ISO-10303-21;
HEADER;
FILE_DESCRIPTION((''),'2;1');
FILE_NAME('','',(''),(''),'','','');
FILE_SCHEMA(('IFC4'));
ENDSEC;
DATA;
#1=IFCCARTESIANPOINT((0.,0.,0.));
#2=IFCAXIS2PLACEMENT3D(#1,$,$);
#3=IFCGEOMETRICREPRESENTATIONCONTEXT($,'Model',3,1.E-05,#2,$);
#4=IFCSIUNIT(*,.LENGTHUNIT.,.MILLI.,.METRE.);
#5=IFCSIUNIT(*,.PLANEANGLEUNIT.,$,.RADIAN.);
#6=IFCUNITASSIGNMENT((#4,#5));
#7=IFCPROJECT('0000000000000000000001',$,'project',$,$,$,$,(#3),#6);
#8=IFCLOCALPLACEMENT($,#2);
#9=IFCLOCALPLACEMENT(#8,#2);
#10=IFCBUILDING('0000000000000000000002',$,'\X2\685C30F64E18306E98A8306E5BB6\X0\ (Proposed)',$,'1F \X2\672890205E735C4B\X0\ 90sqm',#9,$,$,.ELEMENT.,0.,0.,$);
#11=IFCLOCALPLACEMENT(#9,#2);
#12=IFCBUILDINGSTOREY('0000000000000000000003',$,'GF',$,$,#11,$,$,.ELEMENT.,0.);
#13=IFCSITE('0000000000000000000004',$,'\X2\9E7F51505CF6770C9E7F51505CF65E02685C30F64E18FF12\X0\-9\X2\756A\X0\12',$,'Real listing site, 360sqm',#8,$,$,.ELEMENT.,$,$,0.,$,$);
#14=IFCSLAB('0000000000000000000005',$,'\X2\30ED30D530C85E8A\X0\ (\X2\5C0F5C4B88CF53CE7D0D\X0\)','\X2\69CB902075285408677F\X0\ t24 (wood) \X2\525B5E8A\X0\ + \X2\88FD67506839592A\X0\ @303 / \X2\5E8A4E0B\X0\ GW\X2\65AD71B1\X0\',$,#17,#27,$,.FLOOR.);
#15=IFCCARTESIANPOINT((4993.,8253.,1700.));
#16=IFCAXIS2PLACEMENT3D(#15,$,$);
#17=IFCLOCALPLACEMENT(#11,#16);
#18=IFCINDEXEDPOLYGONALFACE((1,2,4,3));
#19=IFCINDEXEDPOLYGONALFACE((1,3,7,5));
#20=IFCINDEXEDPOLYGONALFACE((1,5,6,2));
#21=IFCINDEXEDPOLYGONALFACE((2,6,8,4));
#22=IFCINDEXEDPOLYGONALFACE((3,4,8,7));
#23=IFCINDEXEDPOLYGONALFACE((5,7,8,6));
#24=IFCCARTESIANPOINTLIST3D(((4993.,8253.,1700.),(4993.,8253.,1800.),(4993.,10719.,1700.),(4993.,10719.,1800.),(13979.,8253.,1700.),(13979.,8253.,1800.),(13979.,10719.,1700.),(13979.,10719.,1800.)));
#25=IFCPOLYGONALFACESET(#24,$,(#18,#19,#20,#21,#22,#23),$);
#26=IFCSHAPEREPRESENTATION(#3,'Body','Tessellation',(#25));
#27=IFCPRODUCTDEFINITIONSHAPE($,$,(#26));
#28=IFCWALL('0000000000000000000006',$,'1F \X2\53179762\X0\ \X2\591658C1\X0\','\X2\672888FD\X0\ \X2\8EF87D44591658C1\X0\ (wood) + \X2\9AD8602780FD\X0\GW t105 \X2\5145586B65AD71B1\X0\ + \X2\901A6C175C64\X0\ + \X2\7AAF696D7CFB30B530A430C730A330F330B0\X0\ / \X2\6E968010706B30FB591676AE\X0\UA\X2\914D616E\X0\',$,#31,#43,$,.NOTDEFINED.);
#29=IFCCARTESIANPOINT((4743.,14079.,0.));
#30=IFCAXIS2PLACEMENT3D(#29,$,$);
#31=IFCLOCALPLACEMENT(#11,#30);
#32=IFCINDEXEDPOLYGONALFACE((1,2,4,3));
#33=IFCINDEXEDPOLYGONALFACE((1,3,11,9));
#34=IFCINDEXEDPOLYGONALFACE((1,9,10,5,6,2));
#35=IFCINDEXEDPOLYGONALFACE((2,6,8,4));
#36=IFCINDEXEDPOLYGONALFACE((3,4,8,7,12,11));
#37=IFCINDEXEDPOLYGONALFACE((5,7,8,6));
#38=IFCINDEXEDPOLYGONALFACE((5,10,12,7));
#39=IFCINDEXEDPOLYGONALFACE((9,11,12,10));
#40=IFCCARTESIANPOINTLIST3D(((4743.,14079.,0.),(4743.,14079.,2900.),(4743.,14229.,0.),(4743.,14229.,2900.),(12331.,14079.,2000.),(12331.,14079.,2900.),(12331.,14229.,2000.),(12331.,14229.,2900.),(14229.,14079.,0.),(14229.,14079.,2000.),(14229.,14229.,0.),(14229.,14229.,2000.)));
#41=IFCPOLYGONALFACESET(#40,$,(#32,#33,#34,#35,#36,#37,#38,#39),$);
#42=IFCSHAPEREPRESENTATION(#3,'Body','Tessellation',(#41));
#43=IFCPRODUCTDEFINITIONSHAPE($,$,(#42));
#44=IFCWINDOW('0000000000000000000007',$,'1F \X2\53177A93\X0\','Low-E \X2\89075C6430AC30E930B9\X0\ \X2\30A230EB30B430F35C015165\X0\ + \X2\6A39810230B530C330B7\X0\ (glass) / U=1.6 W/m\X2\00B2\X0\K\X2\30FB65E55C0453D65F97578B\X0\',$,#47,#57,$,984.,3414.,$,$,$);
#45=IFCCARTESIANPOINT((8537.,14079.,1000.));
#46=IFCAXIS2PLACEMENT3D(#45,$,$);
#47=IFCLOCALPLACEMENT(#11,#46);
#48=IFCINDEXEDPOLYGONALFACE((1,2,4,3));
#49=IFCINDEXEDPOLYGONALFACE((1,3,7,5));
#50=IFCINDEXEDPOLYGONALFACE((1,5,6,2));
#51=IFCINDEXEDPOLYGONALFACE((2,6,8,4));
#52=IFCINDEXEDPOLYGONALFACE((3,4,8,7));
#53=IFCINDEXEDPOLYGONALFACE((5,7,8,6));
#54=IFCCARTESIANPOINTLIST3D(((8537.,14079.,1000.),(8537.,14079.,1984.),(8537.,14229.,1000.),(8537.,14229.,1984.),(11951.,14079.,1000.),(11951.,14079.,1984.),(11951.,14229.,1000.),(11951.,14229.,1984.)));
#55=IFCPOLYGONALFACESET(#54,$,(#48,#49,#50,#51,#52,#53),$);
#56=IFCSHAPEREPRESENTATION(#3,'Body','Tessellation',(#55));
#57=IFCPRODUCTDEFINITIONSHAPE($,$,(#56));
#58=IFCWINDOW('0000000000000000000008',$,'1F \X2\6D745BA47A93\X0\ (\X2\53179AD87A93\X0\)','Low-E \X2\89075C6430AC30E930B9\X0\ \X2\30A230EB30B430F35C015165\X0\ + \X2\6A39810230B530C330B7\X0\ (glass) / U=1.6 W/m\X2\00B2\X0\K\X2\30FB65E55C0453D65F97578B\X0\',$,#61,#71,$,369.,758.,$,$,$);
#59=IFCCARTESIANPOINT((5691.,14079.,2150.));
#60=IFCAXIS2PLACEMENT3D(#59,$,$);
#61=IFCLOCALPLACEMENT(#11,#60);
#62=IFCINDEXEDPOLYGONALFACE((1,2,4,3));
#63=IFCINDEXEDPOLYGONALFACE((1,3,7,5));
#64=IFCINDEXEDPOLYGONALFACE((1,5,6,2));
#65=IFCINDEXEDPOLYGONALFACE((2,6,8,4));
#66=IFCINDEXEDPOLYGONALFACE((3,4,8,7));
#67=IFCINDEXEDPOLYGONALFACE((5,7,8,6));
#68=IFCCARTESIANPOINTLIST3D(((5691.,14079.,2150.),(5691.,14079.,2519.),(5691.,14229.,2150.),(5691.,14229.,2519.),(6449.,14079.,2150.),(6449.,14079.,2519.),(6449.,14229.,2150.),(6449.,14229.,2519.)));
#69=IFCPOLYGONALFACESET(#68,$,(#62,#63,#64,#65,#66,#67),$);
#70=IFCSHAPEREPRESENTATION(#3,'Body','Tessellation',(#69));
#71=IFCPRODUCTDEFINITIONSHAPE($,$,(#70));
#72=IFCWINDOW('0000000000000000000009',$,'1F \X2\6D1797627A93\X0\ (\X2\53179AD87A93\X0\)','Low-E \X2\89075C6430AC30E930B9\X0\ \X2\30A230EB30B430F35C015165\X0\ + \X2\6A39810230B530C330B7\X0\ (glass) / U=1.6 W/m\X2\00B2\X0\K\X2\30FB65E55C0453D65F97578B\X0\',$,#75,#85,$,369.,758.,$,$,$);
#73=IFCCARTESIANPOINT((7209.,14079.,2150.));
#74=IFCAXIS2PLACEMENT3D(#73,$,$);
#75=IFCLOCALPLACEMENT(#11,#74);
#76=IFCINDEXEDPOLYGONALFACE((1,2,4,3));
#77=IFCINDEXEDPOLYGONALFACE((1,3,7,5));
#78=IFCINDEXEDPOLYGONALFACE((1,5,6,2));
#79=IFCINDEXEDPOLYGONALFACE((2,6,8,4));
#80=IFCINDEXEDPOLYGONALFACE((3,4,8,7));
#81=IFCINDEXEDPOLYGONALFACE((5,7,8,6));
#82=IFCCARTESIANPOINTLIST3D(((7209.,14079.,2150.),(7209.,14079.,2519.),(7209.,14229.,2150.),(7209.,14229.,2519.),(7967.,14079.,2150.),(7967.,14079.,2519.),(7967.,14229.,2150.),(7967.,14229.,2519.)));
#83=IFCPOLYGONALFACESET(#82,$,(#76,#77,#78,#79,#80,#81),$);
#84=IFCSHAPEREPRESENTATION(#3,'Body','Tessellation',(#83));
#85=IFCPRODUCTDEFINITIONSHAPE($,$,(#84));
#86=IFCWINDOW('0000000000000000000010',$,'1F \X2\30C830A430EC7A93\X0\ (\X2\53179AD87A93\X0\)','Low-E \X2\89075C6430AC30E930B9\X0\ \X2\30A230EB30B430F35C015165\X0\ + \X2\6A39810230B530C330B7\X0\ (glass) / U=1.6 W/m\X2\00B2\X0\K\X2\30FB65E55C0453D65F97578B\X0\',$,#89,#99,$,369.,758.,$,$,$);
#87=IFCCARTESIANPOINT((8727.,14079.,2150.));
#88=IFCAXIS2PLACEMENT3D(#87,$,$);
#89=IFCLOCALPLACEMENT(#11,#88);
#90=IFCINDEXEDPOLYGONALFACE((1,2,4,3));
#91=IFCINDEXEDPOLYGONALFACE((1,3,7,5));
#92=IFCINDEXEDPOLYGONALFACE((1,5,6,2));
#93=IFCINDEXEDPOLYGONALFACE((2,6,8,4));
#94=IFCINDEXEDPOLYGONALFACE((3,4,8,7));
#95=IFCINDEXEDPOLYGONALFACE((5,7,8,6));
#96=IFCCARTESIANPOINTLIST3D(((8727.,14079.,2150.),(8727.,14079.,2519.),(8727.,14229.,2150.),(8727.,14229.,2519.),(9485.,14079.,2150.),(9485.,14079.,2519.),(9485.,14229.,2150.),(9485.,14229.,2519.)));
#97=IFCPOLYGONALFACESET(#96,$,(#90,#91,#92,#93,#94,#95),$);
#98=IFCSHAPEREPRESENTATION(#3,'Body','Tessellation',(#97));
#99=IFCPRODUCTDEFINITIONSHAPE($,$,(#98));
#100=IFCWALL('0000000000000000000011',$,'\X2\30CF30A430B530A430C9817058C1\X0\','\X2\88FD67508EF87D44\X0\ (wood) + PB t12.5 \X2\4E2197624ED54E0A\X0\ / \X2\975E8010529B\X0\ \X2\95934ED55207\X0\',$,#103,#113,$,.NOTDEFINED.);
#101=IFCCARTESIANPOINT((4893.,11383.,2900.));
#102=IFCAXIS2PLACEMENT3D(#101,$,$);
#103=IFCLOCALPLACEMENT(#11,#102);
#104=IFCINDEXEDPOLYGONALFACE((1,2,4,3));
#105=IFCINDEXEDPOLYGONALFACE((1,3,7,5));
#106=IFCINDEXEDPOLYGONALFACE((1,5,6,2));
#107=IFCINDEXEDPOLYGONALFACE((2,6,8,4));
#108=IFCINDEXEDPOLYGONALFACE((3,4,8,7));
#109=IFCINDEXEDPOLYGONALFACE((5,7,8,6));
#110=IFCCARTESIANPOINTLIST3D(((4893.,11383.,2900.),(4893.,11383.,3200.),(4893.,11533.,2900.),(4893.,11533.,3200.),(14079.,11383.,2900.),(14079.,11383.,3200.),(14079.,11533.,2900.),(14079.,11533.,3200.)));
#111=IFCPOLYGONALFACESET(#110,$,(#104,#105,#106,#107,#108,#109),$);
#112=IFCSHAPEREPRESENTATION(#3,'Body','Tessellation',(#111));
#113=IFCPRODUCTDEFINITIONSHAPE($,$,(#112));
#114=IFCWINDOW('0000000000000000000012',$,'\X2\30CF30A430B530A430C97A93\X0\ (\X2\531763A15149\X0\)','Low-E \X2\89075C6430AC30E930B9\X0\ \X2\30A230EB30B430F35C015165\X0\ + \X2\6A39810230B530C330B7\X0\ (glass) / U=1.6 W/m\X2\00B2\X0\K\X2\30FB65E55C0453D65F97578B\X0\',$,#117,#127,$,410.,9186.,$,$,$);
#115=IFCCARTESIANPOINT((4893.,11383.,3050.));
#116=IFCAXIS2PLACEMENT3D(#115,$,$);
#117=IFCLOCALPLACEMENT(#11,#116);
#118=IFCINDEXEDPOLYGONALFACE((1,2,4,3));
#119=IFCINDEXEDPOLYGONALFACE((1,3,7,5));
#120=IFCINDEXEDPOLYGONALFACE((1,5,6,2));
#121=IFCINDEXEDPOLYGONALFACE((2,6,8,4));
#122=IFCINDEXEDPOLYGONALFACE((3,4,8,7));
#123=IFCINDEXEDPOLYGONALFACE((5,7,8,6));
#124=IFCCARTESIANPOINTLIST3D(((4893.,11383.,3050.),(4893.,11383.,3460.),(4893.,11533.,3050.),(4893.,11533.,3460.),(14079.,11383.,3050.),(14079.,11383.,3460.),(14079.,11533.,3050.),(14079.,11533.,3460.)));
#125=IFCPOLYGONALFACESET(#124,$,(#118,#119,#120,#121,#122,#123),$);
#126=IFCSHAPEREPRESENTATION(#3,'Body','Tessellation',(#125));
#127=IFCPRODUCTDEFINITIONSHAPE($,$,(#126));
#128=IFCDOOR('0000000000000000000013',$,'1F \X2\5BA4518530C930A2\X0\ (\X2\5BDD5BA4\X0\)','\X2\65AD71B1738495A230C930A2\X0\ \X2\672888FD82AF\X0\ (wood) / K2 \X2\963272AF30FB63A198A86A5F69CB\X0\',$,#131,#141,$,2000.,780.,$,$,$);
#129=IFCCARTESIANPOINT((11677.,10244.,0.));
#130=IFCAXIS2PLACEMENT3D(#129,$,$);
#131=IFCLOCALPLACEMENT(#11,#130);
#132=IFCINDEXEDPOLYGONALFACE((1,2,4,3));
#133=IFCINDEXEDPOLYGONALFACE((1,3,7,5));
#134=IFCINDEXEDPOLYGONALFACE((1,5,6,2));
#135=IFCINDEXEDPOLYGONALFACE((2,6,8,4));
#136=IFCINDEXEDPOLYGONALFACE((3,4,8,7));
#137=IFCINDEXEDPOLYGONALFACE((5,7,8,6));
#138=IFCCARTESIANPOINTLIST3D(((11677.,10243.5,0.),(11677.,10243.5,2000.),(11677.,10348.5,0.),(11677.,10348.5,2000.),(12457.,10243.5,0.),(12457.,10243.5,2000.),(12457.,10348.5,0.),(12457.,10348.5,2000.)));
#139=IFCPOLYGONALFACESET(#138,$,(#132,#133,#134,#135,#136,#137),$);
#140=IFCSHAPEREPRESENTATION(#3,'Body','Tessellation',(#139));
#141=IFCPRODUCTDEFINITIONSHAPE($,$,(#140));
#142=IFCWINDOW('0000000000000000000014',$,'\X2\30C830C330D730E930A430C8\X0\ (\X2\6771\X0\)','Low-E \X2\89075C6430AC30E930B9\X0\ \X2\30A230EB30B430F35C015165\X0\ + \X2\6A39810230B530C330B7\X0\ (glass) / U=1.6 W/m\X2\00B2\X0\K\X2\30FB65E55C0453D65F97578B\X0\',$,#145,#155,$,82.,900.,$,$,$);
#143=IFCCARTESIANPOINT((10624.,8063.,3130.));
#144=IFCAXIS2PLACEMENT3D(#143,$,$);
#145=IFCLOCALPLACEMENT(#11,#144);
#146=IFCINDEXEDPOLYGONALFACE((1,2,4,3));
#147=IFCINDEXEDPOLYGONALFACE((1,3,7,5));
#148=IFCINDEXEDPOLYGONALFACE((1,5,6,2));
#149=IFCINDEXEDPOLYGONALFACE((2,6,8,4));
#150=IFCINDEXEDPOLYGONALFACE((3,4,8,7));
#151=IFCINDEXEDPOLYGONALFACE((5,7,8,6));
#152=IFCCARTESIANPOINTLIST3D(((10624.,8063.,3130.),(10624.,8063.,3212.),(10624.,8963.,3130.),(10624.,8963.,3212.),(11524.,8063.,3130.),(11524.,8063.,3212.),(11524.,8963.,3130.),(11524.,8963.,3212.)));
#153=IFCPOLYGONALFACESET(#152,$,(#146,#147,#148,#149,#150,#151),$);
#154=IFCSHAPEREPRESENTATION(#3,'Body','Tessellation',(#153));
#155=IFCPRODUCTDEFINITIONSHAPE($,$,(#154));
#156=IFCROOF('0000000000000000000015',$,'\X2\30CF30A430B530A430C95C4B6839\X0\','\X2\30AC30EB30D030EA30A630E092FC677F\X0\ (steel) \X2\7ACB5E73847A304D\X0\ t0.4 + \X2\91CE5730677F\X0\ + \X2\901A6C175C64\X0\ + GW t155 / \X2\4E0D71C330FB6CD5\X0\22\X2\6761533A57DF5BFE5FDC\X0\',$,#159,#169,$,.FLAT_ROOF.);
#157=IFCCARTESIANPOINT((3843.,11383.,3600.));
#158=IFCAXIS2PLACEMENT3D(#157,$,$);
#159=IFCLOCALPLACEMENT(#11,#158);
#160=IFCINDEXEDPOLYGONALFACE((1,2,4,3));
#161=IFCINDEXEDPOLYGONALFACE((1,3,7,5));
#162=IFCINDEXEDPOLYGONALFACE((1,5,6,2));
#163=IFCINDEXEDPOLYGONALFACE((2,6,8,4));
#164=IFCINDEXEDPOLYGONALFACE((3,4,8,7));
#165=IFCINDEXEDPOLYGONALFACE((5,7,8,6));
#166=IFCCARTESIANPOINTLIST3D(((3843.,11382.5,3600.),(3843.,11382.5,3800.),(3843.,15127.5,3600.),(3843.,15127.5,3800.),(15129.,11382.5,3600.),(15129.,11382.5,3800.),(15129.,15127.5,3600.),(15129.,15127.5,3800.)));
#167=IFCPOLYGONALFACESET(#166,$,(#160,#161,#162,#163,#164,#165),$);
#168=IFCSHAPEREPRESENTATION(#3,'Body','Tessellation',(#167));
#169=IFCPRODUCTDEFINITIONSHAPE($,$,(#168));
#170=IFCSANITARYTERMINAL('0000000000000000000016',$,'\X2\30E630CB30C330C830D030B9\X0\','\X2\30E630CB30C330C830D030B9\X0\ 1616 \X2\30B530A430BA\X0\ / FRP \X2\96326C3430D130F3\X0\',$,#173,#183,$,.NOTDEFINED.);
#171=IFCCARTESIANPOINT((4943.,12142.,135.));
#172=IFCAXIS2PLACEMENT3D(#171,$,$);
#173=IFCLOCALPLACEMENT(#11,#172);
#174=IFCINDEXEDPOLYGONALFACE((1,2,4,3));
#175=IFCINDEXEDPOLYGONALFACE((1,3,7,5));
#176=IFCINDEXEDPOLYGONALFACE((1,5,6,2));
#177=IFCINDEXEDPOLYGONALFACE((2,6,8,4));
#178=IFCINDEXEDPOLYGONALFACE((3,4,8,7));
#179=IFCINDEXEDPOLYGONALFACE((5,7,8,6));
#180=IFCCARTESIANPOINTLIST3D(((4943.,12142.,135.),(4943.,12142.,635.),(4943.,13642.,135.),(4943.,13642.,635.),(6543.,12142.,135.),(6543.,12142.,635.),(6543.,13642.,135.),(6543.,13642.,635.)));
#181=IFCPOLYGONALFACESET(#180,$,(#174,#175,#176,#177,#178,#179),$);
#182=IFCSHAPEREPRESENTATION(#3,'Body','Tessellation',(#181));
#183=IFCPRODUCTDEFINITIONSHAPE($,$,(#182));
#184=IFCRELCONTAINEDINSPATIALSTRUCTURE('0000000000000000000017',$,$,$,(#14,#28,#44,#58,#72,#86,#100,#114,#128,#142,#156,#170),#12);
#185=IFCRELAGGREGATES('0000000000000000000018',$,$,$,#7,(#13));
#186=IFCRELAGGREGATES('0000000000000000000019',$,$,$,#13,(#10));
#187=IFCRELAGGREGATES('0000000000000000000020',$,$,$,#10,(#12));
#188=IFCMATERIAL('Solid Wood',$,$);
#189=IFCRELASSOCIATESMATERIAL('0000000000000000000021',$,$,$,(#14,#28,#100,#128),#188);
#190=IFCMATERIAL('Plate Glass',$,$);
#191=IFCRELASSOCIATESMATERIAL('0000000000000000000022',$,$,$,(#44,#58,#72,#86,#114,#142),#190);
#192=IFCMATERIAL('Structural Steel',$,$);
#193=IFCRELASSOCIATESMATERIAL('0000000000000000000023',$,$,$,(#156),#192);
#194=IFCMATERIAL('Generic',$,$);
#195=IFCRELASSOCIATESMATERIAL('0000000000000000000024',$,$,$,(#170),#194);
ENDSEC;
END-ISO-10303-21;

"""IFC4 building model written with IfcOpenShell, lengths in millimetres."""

from ifc_helpers import new_model, si_unit, frame, frame_2d, origin, place, context, project, spatial, rectangle, extrude, material, element, fill, save


model = new_model("IFC4")

# Units and contexts
model_context = context("Model", 3, precision=1e-05, world=origin())
ifc_project = project(units=[si_unit("LENGTHUNIT", "METRE", prefix="MILLI"), si_unit("PLANEANGLEUNIT", "RADIAN")], contexts=[model_context])

# Site, building, storey
site_placement = place(None, origin())
site = spatial("IfcSite", under=ifc_project, at=site_placement, Name="鹿児島県鹿児島市桜ヶ丘２-9番12", ObjectType="Real listing site, 360sqm", CompositionType="ELEMENT", RefElevation=0.0)
building_placement = place(site_placement, origin())
building = spatial("IfcBuilding", under=site, at=building_placement, Name="桜ヶ丘の風の家 (Proposed)", ObjectType="1F 木造平屋 90sqm", CompositionType="ELEMENT", ElevationOfRefHeight=0.0, ElevationOfTerrain=0.0)
storey_placement = place(building_placement, origin())
storey = spatial("IfcBuildingStorey", under=building, at=storey_placement, Name="GF", CompositionType="ELEMENT", Elevation=0.0)

# Slab
ifc_material_1 = material(Name="Solid Wood")
slab_placement = place(storey_placement, frame((4993.0, 8253.0, 1700.0)))
element("IfcSlab", 1, at=slab_placement, inside=storey, material=ifc_material_1, Name="ロフト床 (小屋裏収納)", Description="構造用合板 t24 (wood) 剛床 + 製材根太 @303 / 床下 GW断熱", PredefinedType="FLOOR", context=model_context, shape_type="SweptSolid", body=[
    extrude(rectangle(XDim=8986.0, YDim=2466.0, at=frame_2d((4493.0, 1233.0))), frame((4993.0, 8253.0, 1700.0)), (0.0, 0.0, 1.0), 100.0),
])

# Wall, openings, windows
wall_1_placement = place(storey_placement, frame((4743.0, 14079.0, 0.0)))
wall_1 = element("IfcWall", 2, at=wall_1_placement, inside=storey, material=ifc_material_1, Name="1F 北面 外壁", Description="木製 軸組外壁 (wood) + 高性能GW t105 充填断熱 + 通気層 + 窯業系サイディング / 準耐火・外皮UA配慮", PredefinedType="NOTDEFINED", context=model_context, shape_type="SweptSolid", body=[
    extrude(rectangle(XDim=9486.0, YDim=150.0, at=frame_2d((4743.0, 75.0))), frame((4743.0, 14079.0, 0.0)), (0.0, 0.0, 1.0), 2900.0),
])
opening_1_placement = place(storey_placement, frame((8537.0, 14079.0, 1000.0)))
opening_1 = element("IfcOpeningElement", 3, at=opening_1_placement, cuts=wall_1, PredefinedType="NOTDEFINED", context=model_context, shape_type="SweptSolid", body=[
    extrude(rectangle(XDim=3414.0, YDim=150.0, at=frame_2d((1707.0, 75.0))), frame((8537.0, 14079.0, 1000.0)), (0.0, 0.0, 1.0), 984.0),
])
opening_2_placement = place(storey_placement, frame((5691.0, 14079.0, 2150.0)))
opening_2 = element("IfcOpeningElement", 4, at=opening_2_placement, cuts=wall_1, PredefinedType="NOTDEFINED", context=model_context, shape_type="SweptSolid", body=[
    extrude(rectangle(XDim=758.0, YDim=150.0, at=frame_2d((379.0, 75.0))), frame((5691.0, 14079.0, 2150.0)), (0.0, 0.0, 1.0), 369.0),
])
opening_3_placement = place(storey_placement, frame((7209.0, 14079.0, 2150.0)))
opening_3 = element("IfcOpeningElement", 5, at=opening_3_placement, cuts=wall_1, PredefinedType="NOTDEFINED", context=model_context, shape_type="SweptSolid", body=[
    extrude(rectangle(XDim=758.0, YDim=150.0, at=frame_2d((379.0, 75.0))), frame((7209.0, 14079.0, 2150.0)), (0.0, 0.0, 1.0), 369.0),
])
opening_4_placement = place(storey_placement, frame((8727.0, 14079.0, 2150.0)))
opening_4 = element("IfcOpeningElement", 6, at=opening_4_placement, cuts=wall_1, PredefinedType="NOTDEFINED", context=model_context, shape_type="SweptSolid", body=[
    extrude(rectangle(XDim=758.0, YDim=150.0, at=frame_2d((379.0, 75.0))), frame((8727.0, 14079.0, 2150.0)), (0.0, 0.0, 1.0), 369.0),
])
ifc_material_2 = material(Name="Plate Glass")
window_1_placement = place(storey_placement, frame((8537.0, 14079.0, 1000.0)))
window_1 = element("IfcWindow", 7, at=window_1_placement, inside=storey, material=ifc_material_2, Name="1F 北窓", Description="Low-E 複層ガラス アルゴン封入 + 樹脂サッシ (glass) / U=1.6 W/m²K・日射取得型", OverallHeight=984.0, OverallWidth=3414.0, context=model_context, shape_type="SweptSolid", body=[
    extrude(rectangle(XDim=3414.0, YDim=150.0, at=frame_2d((1707.0, 75.0))), frame((8537.0, 14079.0, 1000.0)), (0.0, 0.0, 1.0), 984.0),
])
fill(opening_1, window_1)
window_2_placement = place(storey_placement, frame((5691.0, 14079.0, 2150.0)))
window_2 = element("IfcWindow", 8, at=window_2_placement, inside=storey, material=ifc_material_2, Name="1F 浴室窓 (北高窓)", Description="Low-E 複層ガラス アルゴン封入 + 樹脂サッシ (glass) / U=1.6 W/m²K・日射取得型", OverallHeight=369.0, OverallWidth=758.0, context=model_context, shape_type="SweptSolid", body=[
    extrude(rectangle(XDim=758.0, YDim=150.0, at=frame_2d((379.0, 75.0))), frame((5691.0, 14079.0, 2150.0)), (0.0, 0.0, 1.0), 369.0),
])
fill(opening_2, window_2)
window_3_placement = place(storey_placement, frame((7209.0, 14079.0, 2150.0)))
window_3 = element("IfcWindow", 9, at=window_3_placement, inside=storey, material=ifc_material_2, Name="1F 洗面窓 (北高窓)", Description="Low-E 複層ガラス アルゴン封入 + 樹脂サッシ (glass) / U=1.6 W/m²K・日射取得型", OverallHeight=369.0, OverallWidth=758.0, context=model_context, shape_type="SweptSolid", body=[
    extrude(rectangle(XDim=758.0, YDim=150.0, at=frame_2d((379.0, 75.0))), frame((7209.0, 14079.0, 2150.0)), (0.0, 0.0, 1.0), 369.0),
])
fill(opening_3, window_3)
window_4_placement = place(storey_placement, frame((8727.0, 14079.0, 2150.0)))
window_4 = element("IfcWindow", 10, at=window_4_placement, inside=storey, material=ifc_material_2, Name="1F トイレ窓 (北高窓)", Description="Low-E 複層ガラス アルゴン封入 + 樹脂サッシ (glass) / U=1.6 W/m²K・日射取得型", OverallHeight=369.0, OverallWidth=758.0, context=model_context, shape_type="SweptSolid", body=[
    extrude(rectangle(XDim=758.0, YDim=150.0, at=frame_2d((379.0, 75.0))), frame((8727.0, 14079.0, 2150.0)), (0.0, 0.0, 1.0), 369.0),
])
fill(opening_4, window_4)

# Wall, opening, window
wall_2_placement = place(storey_placement, frame((4893.0, 11383.0, 2900.0)))
wall_2 = element("IfcWall", 11, at=wall_2_placement, inside=storey, material=ifc_material_1, Name="ハイサイド腰壁", Description="製材軸組 (wood) + PB t12.5 両面仕上 / 非耐力 間仕切", PredefinedType="NOTDEFINED", context=model_context, shape_type="SweptSolid", body=[
    extrude(rectangle(XDim=9186.0, YDim=150.0, at=frame_2d((4593.0, 75.0))), frame((4893.0, 11383.0, 2900.0)), (0.0, 0.0, 1.0), 700.0),
])
opening_5_placement = place(storey_placement, frame((4893.0, 11383.0, 3050.0)))
opening_5 = element("IfcOpeningElement", 12, at=opening_5_placement, cuts=wall_2, PredefinedType="NOTDEFINED", context=model_context, shape_type="SweptSolid", body=[
    extrude(rectangle(XDim=9186.0, YDim=150.0, at=frame_2d((4593.0, 75.0))), frame((4893.0, 11383.0, 3050.0)), (0.0, 0.0, 1.0), 410.0),
])
window_5_placement = place(storey_placement, frame((4893.0, 11383.0, 3050.0)))
window_5 = element("IfcWindow", 13, at=window_5_placement, inside=storey, material=ifc_material_2, Name="ハイサイド窓 (北採光)", Description="Low-E 複層ガラス アルゴン封入 + 樹脂サッシ (glass) / U=1.6 W/m²K・日射取得型", OverallHeight=410.0, OverallWidth=9186.0, context=model_context, shape_type="SweptSolid", body=[
    extrude(rectangle(XDim=9186.0, YDim=150.0, at=frame_2d((4593.0, 75.0))), frame((4893.0, 11383.0, 3050.0)), (0.0, 0.0, 1.0), 410.0),
])
fill(opening_5, window_5)

# Door
door_1_placement = place(storey_placement, frame((11677.0, 10244.0, 0.0)))
element("IfcDoor", 14, at=door_1_placement, inside=storey, material=ifc_material_1, Name="1F 室内ドア (寝室)", Description="断熱玄関ドア 木製芯 (wood) / K2 防犯・採風機構", OverallHeight=2000.0, OverallWidth=780.0, context=model_context, shape_type="SweptSolid", body=[
    extrude(rectangle(XDim=780.0, YDim=105.0, at=frame_2d((390.0, 52.0))), frame((11677.0, 10244.0, 0.0)), (0.0, 0.0, 1.0), 2000.0),
])

# Window
window_6_placement = place(storey_placement, frame((10624.0, 8063.0, 3130.0)))
element("IfcWindow", 15, at=window_6_placement, inside=storey, material=ifc_material_2, Name="トップライト (東)", Description="Low-E 複層ガラス アルゴン封入 + 樹脂サッシ (glass) / U=1.6 W/m²K・日射取得型", OverallHeight=82.0, OverallWidth=900.0, context=model_context, shape_type="SweptSolid", body=[
    extrude(rectangle(XDim=900.0, YDim=900.0, at=frame_2d((450.0, 450.0))), frame((10624.0, 8063.0, 3130.0)), (0.0, 0.0, 1.0), 82.0),
])

# Roof
ifc_material_3 = material(Name="Structural Steel")
roof_placement = place(storey_placement, frame((3843.0, 11383.0, 3600.0)))
element("IfcRoof", 16, at=roof_placement, inside=storey, material=ifc_material_3, Name="ハイサイド屋根", Description="ガルバリウム鋼板 (steel) 立平葺き t0.4 + 野地板 + 通気層 + GW t155 / 不燃・法22条区域対応", PredefinedType="FLAT_ROOF", context=model_context, shape_type="SweptSolid", body=[
    extrude(rectangle(XDim=11286.0, YDim=3745.0, at=frame_2d((5643.0, 1872.0))), frame((3843.0, 11383.0, 3600.0)), (0.0, 0.0, 1.0), 200.0),
])

# Sanitary terminal
ifc_material_4 = material(Name="Generic")
sanitary_terminal_1_placement = place(storey_placement, frame((4943.0, 12142.0, 135.0)))
element("IfcSanitaryTerminal", 17, at=sanitary_terminal_1_placement, inside=storey, material=ifc_material_4, Name="ユニットバス", Description="ユニットバス 1616 サイズ / FRP 防水パン", PredefinedType="NOTDEFINED", context=model_context, shape_type="SweptSolid", body=[
    extrude(rectangle(XDim=1600.0, YDim=1500.0, at=frame_2d((800.0, 750.0))), frame((4943.0, 12142.0, 135.0)), (0.0, 0.0, 1.0), 500.0),
])

save(model, "model.ifc")
